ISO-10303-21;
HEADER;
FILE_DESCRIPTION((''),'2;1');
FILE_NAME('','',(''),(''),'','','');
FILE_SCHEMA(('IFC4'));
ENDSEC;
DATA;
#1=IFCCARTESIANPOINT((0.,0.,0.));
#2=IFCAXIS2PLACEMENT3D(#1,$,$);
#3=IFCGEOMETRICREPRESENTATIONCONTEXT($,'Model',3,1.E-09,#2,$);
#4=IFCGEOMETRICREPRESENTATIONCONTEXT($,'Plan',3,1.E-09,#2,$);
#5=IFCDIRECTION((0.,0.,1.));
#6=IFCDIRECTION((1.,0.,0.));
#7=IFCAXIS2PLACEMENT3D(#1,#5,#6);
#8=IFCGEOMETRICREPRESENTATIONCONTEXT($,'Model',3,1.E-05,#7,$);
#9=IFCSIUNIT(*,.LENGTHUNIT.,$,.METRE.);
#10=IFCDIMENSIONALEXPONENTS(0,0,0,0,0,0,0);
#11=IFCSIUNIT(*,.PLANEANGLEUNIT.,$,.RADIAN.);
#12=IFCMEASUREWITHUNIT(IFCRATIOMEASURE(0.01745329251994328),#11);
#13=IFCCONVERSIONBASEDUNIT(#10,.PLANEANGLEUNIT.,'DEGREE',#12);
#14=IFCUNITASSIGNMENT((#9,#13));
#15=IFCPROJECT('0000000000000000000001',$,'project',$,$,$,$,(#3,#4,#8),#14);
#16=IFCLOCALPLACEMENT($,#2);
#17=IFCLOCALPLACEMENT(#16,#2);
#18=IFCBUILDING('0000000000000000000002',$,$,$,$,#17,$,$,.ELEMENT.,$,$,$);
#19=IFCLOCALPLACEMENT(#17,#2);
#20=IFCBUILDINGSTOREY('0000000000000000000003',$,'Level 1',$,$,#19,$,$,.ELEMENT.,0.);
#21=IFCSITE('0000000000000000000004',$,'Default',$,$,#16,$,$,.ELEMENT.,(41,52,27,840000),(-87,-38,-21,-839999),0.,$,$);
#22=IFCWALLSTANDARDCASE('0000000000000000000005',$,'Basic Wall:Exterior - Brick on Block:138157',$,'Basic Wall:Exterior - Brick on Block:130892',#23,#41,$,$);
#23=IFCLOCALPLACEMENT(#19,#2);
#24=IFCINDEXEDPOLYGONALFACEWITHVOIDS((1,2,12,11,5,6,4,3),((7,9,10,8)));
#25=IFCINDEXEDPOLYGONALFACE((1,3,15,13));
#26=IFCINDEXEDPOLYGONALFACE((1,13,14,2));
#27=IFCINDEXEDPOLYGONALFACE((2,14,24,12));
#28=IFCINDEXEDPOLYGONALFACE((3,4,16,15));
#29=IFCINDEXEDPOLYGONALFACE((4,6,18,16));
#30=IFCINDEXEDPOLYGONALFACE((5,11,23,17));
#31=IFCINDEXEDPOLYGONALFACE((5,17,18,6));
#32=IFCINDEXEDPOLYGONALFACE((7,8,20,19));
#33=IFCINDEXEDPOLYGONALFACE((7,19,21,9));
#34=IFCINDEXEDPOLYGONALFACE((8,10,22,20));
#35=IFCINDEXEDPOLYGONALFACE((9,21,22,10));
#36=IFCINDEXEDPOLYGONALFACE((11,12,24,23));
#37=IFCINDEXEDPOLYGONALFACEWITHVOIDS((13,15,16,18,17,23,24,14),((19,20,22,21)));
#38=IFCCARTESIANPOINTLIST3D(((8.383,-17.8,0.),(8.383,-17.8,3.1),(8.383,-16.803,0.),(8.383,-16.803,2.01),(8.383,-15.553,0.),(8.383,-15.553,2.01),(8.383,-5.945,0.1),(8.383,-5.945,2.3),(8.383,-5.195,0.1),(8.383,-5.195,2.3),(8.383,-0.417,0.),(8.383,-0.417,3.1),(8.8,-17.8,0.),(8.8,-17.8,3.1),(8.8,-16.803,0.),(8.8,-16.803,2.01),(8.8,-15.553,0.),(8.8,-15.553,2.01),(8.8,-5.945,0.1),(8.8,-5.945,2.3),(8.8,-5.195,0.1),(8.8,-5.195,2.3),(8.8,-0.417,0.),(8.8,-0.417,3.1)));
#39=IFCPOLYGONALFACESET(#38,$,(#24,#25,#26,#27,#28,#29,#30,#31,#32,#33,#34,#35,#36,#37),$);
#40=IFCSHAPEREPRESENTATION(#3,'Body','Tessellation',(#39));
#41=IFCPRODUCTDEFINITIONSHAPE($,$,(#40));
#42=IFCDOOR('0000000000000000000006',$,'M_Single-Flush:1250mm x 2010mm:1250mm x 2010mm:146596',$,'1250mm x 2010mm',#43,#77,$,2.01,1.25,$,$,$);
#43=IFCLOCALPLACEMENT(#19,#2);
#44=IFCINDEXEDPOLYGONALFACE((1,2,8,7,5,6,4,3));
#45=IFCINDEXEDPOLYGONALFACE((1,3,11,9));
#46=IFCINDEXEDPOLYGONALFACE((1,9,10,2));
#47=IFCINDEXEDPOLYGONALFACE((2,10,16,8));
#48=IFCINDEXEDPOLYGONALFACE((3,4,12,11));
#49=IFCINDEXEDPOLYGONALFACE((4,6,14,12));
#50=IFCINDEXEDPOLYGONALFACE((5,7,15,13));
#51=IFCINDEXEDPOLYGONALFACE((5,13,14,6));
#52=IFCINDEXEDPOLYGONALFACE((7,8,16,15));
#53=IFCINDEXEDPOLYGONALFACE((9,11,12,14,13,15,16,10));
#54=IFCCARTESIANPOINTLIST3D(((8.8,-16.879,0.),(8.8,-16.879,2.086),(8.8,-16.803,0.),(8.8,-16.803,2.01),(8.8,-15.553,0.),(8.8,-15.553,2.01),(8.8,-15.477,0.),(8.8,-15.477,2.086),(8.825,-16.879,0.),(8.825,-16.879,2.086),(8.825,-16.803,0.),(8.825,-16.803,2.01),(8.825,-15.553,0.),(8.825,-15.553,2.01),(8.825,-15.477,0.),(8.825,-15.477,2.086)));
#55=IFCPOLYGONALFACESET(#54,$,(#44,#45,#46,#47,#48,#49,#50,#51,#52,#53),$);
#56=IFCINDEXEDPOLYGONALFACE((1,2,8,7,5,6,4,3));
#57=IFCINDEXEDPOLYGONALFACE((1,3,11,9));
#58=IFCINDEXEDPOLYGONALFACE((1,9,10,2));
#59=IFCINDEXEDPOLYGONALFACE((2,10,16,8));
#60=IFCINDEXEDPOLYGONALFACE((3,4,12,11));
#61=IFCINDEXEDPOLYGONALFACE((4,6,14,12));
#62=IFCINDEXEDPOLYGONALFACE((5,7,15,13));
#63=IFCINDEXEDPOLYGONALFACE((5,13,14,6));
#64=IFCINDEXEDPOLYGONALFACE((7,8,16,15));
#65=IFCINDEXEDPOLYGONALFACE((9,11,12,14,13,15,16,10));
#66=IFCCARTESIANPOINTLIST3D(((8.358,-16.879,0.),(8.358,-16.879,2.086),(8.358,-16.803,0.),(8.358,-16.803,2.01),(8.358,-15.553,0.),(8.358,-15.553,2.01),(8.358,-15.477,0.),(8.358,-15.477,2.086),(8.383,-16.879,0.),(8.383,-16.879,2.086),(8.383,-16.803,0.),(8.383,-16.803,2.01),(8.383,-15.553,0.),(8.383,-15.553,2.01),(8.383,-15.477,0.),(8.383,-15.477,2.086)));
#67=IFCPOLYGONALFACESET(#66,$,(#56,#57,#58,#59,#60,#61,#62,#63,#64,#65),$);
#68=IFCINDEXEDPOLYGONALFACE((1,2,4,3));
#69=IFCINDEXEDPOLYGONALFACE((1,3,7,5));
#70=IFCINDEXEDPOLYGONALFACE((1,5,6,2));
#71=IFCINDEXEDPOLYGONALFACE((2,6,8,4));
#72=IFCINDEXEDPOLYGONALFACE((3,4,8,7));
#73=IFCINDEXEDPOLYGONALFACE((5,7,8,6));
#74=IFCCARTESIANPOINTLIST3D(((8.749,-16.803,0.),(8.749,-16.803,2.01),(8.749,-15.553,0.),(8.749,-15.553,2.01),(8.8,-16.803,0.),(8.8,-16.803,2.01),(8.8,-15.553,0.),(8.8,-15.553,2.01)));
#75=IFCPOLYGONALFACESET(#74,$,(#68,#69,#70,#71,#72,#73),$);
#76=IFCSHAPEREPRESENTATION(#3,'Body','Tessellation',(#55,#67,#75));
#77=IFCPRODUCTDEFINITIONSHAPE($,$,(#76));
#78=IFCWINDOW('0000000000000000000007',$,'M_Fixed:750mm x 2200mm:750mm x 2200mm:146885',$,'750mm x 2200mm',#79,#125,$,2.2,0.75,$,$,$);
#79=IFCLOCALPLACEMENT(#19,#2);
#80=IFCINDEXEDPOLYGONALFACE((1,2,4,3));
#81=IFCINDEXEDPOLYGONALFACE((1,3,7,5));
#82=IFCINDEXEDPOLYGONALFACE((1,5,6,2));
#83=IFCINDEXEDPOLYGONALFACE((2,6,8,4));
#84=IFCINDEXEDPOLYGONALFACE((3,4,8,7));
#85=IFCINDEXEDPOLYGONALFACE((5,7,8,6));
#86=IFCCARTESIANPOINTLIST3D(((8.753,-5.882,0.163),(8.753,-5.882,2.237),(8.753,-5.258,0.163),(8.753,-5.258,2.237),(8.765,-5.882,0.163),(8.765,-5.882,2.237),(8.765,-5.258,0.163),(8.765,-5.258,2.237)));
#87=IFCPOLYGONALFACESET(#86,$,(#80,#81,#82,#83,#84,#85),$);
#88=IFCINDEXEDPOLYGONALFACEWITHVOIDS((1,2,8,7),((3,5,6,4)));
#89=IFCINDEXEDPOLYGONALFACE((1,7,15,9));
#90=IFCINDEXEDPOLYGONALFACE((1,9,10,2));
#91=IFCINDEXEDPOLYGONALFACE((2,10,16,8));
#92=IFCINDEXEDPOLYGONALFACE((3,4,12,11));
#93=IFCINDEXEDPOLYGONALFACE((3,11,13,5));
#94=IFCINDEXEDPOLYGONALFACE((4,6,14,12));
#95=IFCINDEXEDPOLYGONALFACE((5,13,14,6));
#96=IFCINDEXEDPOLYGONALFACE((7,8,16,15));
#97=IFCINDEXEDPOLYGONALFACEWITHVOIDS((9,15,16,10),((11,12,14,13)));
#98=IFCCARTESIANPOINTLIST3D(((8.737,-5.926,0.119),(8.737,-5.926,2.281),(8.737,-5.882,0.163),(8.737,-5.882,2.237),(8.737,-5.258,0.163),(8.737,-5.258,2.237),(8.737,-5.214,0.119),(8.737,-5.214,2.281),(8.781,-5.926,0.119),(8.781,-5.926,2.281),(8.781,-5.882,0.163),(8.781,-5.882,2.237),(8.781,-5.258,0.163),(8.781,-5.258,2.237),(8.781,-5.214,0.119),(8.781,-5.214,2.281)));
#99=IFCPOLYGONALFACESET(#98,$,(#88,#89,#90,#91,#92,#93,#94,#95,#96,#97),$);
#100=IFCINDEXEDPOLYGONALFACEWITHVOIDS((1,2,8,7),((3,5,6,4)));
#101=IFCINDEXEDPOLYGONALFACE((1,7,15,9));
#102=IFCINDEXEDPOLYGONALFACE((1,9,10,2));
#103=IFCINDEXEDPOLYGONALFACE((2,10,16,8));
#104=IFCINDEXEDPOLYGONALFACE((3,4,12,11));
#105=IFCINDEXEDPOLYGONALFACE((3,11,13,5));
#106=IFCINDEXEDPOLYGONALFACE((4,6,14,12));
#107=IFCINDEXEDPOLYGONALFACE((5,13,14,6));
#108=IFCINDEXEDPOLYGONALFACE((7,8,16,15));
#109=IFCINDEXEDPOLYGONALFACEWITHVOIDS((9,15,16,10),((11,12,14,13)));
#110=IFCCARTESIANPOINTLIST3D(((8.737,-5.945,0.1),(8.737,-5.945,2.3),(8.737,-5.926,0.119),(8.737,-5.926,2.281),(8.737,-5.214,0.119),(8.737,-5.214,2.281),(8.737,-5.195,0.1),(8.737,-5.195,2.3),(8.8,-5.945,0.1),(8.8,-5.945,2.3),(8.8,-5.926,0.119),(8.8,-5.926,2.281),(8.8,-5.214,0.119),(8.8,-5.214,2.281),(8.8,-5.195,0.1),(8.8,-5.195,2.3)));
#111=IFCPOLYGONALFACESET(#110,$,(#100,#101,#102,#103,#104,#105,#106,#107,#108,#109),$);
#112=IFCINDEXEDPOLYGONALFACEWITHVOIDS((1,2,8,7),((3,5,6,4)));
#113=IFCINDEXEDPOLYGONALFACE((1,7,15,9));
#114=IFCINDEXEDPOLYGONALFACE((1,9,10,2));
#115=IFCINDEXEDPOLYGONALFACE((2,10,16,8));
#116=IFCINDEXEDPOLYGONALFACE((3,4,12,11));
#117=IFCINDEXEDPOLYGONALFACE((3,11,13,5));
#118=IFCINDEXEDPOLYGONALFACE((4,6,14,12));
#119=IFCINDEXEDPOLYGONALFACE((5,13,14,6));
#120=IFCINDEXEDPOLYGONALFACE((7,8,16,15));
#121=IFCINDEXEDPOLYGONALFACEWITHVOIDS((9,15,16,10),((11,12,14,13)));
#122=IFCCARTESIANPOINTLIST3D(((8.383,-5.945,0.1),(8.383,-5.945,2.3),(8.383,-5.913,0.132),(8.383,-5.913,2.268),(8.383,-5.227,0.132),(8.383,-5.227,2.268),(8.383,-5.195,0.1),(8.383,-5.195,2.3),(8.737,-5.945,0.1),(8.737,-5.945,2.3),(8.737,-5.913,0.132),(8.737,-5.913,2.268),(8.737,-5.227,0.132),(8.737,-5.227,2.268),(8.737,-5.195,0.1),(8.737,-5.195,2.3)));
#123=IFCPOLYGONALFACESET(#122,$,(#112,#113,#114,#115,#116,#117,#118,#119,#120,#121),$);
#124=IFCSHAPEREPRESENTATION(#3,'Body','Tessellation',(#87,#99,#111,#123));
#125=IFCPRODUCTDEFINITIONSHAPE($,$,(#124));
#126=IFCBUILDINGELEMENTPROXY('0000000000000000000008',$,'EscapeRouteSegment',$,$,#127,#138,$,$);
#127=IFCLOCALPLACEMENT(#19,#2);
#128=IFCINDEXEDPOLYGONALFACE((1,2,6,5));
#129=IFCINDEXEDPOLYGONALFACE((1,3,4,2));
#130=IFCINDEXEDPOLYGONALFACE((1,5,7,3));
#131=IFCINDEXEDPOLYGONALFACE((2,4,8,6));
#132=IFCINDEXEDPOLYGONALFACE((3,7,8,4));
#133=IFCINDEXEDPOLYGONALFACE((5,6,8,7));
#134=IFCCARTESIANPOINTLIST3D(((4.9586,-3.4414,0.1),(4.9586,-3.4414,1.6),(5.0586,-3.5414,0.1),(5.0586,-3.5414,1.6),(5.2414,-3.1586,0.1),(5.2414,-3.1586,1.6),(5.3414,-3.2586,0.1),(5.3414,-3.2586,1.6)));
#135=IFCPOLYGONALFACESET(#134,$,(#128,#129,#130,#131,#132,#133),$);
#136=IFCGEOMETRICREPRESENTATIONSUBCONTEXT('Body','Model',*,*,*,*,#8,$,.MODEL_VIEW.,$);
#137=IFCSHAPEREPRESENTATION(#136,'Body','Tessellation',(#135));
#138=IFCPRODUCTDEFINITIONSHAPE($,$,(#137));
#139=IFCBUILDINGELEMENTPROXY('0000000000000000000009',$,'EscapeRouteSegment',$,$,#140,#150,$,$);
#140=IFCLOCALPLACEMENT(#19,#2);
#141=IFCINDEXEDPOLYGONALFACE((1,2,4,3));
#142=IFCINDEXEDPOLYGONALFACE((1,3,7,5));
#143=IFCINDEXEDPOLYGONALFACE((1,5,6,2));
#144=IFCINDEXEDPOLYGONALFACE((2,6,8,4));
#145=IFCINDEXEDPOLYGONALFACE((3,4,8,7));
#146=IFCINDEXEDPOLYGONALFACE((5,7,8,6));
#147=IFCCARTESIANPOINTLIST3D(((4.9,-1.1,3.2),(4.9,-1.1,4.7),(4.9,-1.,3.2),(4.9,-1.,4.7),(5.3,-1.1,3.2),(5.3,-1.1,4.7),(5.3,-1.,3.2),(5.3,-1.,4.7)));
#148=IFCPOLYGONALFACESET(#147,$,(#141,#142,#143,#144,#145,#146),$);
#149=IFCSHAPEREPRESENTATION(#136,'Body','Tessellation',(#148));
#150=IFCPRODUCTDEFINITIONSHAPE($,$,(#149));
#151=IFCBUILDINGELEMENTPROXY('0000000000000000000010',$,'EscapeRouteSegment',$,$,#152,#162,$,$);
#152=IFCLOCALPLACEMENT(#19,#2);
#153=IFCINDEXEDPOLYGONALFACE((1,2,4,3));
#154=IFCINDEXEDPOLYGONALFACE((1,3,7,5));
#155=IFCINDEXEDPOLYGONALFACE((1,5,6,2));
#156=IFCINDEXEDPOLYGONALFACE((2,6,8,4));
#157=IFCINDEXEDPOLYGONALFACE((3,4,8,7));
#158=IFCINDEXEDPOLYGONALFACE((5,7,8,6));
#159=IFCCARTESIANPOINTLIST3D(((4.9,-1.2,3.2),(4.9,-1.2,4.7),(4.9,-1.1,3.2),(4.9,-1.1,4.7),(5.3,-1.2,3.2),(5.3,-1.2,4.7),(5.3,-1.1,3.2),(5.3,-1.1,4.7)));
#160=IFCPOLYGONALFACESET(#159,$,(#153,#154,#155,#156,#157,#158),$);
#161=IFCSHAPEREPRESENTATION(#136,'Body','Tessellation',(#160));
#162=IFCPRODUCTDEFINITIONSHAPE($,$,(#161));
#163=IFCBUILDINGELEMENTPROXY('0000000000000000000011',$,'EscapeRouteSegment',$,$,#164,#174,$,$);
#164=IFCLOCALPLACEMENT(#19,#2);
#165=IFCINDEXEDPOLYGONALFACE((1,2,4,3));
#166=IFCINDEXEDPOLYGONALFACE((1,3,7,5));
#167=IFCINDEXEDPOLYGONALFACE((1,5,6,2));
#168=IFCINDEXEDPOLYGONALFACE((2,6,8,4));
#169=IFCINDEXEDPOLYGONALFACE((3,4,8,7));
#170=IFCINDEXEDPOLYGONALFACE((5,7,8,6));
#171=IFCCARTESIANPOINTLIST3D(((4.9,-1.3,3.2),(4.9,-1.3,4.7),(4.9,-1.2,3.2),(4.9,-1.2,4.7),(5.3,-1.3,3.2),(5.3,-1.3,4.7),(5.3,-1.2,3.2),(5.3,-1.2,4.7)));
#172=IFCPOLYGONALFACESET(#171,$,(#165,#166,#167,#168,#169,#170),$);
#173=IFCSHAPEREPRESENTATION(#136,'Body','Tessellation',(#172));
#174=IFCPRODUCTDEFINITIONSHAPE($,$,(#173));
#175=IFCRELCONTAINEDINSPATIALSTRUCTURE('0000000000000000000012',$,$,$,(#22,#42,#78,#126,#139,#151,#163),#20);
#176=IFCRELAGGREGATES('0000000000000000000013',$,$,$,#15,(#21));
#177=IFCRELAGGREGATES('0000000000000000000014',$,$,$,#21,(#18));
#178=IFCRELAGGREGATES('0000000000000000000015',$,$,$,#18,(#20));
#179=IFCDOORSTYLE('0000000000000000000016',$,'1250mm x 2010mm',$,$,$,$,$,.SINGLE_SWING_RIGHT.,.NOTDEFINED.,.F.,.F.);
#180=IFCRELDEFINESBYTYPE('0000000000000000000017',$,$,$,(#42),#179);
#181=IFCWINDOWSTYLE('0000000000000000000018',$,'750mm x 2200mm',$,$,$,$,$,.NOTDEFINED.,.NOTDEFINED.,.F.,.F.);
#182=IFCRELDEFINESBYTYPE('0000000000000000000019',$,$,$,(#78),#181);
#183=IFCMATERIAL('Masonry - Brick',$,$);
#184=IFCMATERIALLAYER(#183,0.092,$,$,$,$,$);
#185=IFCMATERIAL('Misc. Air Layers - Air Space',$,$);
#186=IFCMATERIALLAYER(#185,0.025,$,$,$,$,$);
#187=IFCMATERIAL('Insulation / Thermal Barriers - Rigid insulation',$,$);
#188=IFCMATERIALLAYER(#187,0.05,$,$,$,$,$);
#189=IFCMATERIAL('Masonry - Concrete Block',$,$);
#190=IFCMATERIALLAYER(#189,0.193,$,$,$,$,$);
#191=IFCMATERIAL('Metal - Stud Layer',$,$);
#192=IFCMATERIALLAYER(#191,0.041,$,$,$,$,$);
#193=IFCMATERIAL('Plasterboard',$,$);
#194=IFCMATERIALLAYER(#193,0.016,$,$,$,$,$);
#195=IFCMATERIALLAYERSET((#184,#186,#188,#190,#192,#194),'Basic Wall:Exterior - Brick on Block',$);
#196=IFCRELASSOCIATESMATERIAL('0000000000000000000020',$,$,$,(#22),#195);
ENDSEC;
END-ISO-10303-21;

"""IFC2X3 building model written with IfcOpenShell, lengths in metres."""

from ifc_helpers import new_model, entity, si_unit, converted_unit, frame, frame_2d, origin, origin_with_axes, origin_2d_with_axis, place, context, subcontext, project, spatial, polyline, rectangle, outline, extrude, source, transform, mapped, material, layer, layer_set, layer_usage, type_object, type_shapes, element, fill, save


model = new_model("IFC2X3")

# Units and contexts
model_context_1 = context("Model", 3, precision=1e-09, world=origin())
plan_context = context("Plan", 3, precision=1e-09, world=origin())
model_context_2 = context("Model", 3, precision=1e-05, world=origin_with_axes())
body_context = subcontext(model_context_2, "Body", "Model", "MODEL_VIEW")
ifc_project = project(units=[si_unit("LENGTHUNIT", "METRE"), converted_unit("PLANEANGLEUNIT", "DEGREE", entity("IfcRatioMeasure", 0.01745329251994328), si_unit("PLANEANGLEUNIT", "RADIAN"), dimensions=[0, 0, 0, 0, 0, 0, 0])], contexts=[model_context_1, plan_context, model_context_2])

# Site, building, storey
site_placement = place(None, origin())
site = spatial("IfcSite", under=ifc_project, at=site_placement, Name="Default", CompositionType="ELEMENT", RefLatitude=(41, 52, 27, 840000), RefLongitude=(-87, -38, -21, -839999), RefElevation=0.0)
building_placement = place(site_placement, origin())
building = spatial("IfcBuilding", under=site, at=building_placement, CompositionType="ELEMENT")
storey_placement = place(building_placement, origin())
storey = spatial("IfcBuildingStorey", under=building, at=storey_placement, Name="Level 1", CompositionType="ELEMENT", Elevation=0.0)

# Wall, openings, door, window
ifc_material_1 = material(Name="Masonry - Brick")
ifc_layer_1 = layer(ifc_material_1, 0.092)
ifc_material_2 = material(Name="Misc. Air Layers - Air Space")
ifc_layer_2 = layer(ifc_material_2, 0.025)
ifc_material_3 = material(Name="Insulation / Thermal Barriers - Rigid insulation")
ifc_layer_3 = layer(ifc_material_3, 0.05)
ifc_material_4 = material(Name="Masonry - Concrete Block")
ifc_layer_4 = layer(ifc_material_4, 0.193)
ifc_material_5 = material(Name="Metal - Stud Layer")
ifc_layer_5 = layer(ifc_material_5, 0.041)
ifc_material_6 = material(Name="Plasterboard")
ifc_layer_6 = layer(ifc_material_6, 0.016)
ifc_layer_set = layer_set([ifc_layer_1, ifc_layer_2, ifc_layer_3, ifc_layer_4, ifc_layer_5, ifc_layer_6], Name="Basic Wall:Exterior - Brick on Block")
ifc_layer_usage = layer_usage(ifc_layer_set, "AXIS2", "NEGATIVE", 0.2085)
wall_placement = place(storey_placement, frame((8.5915, -0.417, 0.0), z_axis=(0.0, 0.0, 1.0), x_axis=(0.0, -1.0, 0.0)))
wall = element("IfcWallStandardCase", 1, at=wall_placement, inside=storey, material=ifc_layer_usage, Name="Basic Wall:Exterior - Brick on Block:138157", ObjectType="Basic Wall:Exterior - Brick on Block:130892", context=model_context_1, shape_type="SweptSolid", body=[
    extrude(rectangle(XDim=17.383, YDim=0.417, at=frame_2d((8.6915, 0.0), x_axis=(-1.0, 0.0))), origin(), (0.0, 0.0, 1.0), 3.1),
])
opening_1_placement = place(wall_placement, frame((15.136, -0.2085, 0.0)))
opening_1 = element("IfcOpeningElement", 2, at=opening_1_placement, cuts=wall, ObjectType="Opening", context=model_context_1, shape_type="SweptSolid", body=[
    extrude(rectangle(XDim=1.25, YDim=2.01, at=frame_2d((1.005, 0.625), x_axis=(0.0, 1.0))), frame((0.0, 0.0, 0.0), z_axis=(0.0, 1.0, 0.0), x_axis=(0.0, 0.0, 1.0)), (0.0, 0.0, 1.0), 0.417),
])
opening_2_placement = place(wall_placement, frame((4.778, -0.2085, 0.1)))
opening_2 = element("IfcOpeningElement", 3, at=opening_2_placement, cuts=wall, ObjectType="Opening", context=model_context_1, shape_type="SweptSolid", body=[
    extrude(rectangle(XDim=2.2, YDim=0.75, at=frame_2d((1.1, 0.375), x_axis=(1.0, 0.0))), frame((0.0, 0.0, 0.0), z_axis=(0.0, 1.0, 0.0), x_axis=(0.0, 0.0, 1.0)), (0.0, 0.0, 1.0), 0.417),
])
door_style = type_object("IfcDoorStyle", Name="1250mm x 2010mm", ConstructionType="NOTDEFINED", OperationType="SINGLE_SWING_RIGHT", ParameterTakesPrecedence=False, Sizeable=False)
shared_shape_1 = source(origin(), model_context_1, "Body", "SweptSolid", [
    extrude(outline(polyline([(-0.701, -1.062), (0.701, -1.062), (0.701, 1.024), (0.625, 1.024), (0.625, -0.986), (-0.625, -0.986), (-0.625, 1.024), (-0.701, 1.024), (-0.701, -1.062)])), frame((0.625, 0.417, 1.024), z_axis=(0.0, 1.0, 0.0), x_axis=(1.0, 0.0, 0.0)), (0.0, 0.0, 1.0), 0.025),
    extrude(outline(polyline([(-1.062, -0.701), (1.024, -0.701), (1.024, -0.625), (-0.986, -0.625), (-0.986, 0.625), (1.024, 0.625), (1.024, 0.701), (-1.062, 0.701), (-1.062, -0.701)])), frame((0.625, -0.025, 1.024), z_axis=(0.0, 1.0, 0.0), x_axis=(0.0, 0.0, -1.0)), (0.0, 0.0, 1.0), 0.025),
    extrude(rectangle(XDim=0.051, YDim=1.25, at=origin_2d_with_axis()), frame((0.625, 0.3915, 0.0), z_axis=(0.0, 0.0, 1.0), x_axis=(0.0, 1.0, 0.0)), (0.0, 0.0, 1.0), 2.01),
])
type_shapes(door_style, [shared_shape_1])
door_placement = place(opening_1_placement, origin())
door = element("IfcDoor", 4, at=door_placement, inside=storey, type_object=door_style, Name="M_Single-Flush:1250mm x 2010mm:1250mm x 2010mm:146596", ObjectType="1250mm x 2010mm", OverallHeight=2.01, OverallWidth=1.25, context=model_context_1, shape_type="MappedRepresentation", body=[
    mapped(shared_shape_1, transform((0.0, 0.0, 0.0), scale=1.0)),
])
fill(opening_1, door)
window_style = type_object("IfcWindowStyle", Name="750mm x 2200mm", ConstructionType="NOTDEFINED", OperationType="NOTDEFINED", ParameterTakesPrecedence=False, Sizeable=False)
shared_shape_2 = source(origin(), model_context_1, "Body", "SweptSolid", [
    extrude(rectangle(XDim=0.012, YDim=0.624, at=origin_2d_with_axis()), frame((0.375, 0.376, 0.063), z_axis=(0.0, 0.0, 1.0), x_axis=(0.0, -1.0, 0.0)), (0.0, 0.0, 1.0), 2.074),
    extrude(outline(polyline([(-0.356, -1.081), (0.356, -1.081), (0.356, 1.081), (-0.356, 1.081), (-0.356, -1.081)]), holes=[polyline([(-0.312, -1.037), (-0.312, 1.037), (0.312, 1.037), (0.312, -1.037), (-0.312, -1.037)])]), frame((0.375, 0.354, 1.1), z_axis=(0.0, 1.0, 0.0), x_axis=(1.0, 0.0, 0.0)), (0.0, 0.0, 1.0), 0.044),
    extrude(outline(polyline([(-0.375, -1.1), (0.375, -1.1), (0.375, 1.1), (-0.375, 1.1), (-0.375, -1.1)]), holes=[polyline([(-0.356, -1.081), (-0.356, 1.081), (0.356, 1.081), (0.356, -1.081), (-0.356, -1.081)])]), frame((0.375, 0.354, 1.1), z_axis=(0.0, 1.0, 0.0), x_axis=(1.0, 0.0, 0.0)), (0.0, 0.0, 1.0), 0.063),
    extrude(outline(polyline([(-0.375, -1.1), (0.375, -1.1), (0.375, 1.1), (-0.375, 1.1), (-0.375, -1.1)]), holes=[polyline([(-0.343, -1.068), (-0.343, 1.068), (0.343, 1.068), (0.343, -1.068), (-0.343, -1.068)])]), frame((0.375, 0.0, 1.1), z_axis=(0.0, 1.0, 0.0), x_axis=(1.0, 0.0, 0.0)), (0.0, 0.0, 1.0), 0.354),
])
type_shapes(window_style, [shared_shape_2])
window_placement = place(opening_2_placement, origin())
window = element("IfcWindow", 5, at=window_placement, inside=storey, type_object=window_style, Name="M_Fixed:750mm x 2200mm:750mm x 2200mm:146885", ObjectType="750mm x 2200mm", OverallHeight=2.2, OverallWidth=0.75, context=model_context_1, shape_type="MappedRepresentation", body=[
    mapped(shared_shape_2, transform((0.0, 0.0, 0.0), scale=1.0)),
])
fill(opening_2, window)

# Building element proxies
proxy_1_placement = place(storey_placement, frame((5.2, -3.4, 0.1), z_axis=(0.0, 0.0, 1.0), x_axis=(-0.707106, 0.707108, 0.0)))
element("IfcBuildingElementProxy", 6, at=proxy_1_placement, inside=storey, Name="EscapeRouteSegment", context=body_context, shape_type="SweptSolid", body=[
    extrude(outline(polyline([(0.0, -0.2), (0.0, 0.2), (0.1414, 0.2), (0.1414, -0.2), (0.0, -0.2)])), origin_with_axes(), (0.0, 0.0, 1.0), 1.5),
])
for number, where, z_axis, x_axis, name in (
    (7, (5.1, -1.0, 3.2), (0.0, 0.0, 1.0), (0.0, -1.0, 0.0), "EscapeRouteSegment"),
    (8, (5.1, -1.1, 3.2), (0.0, 0.0, 1.0), (0.0, -1.0, 0.0), "EscapeRouteSegment"),
):
    element("IfcBuildingElementProxy", number, at=place(storey_placement, frame(where, z_axis=z_axis, x_axis=x_axis)), inside=storey, Name=name, context=body_context, shape_type="SweptSolid", body=[
        extrude(outline(polyline([(0.0, -0.2), (0.0, 0.2), (0.1, 0.2), (0.1, -0.2), (0.0, -0.2)])), origin_with_axes(), (0.0, 0.0, 1.0), 1.5),
    ])
proxy_2_placement = place(storey_placement, frame((5.1, -1.2, 3.2), z_axis=(0.0, 0.0, 1.0), x_axis=(0.0, -1.0, 0.0)))
element("IfcBuildingElementProxy", 9, at=proxy_2_placement, inside=storey, Name="EscapeRouteSegment", context=body_context, shape_type="SweptSolid", body=[
    extrude(outline(polyline([(0.0, -0.2), (0.0, 0.2), (0.1, 0.2), (0.1, -0.2), (0.0, -0.2)])), origin_with_axes(), (0.0, 0.0, 1.0), 1.5),
])

save(model, "model.ifc")
